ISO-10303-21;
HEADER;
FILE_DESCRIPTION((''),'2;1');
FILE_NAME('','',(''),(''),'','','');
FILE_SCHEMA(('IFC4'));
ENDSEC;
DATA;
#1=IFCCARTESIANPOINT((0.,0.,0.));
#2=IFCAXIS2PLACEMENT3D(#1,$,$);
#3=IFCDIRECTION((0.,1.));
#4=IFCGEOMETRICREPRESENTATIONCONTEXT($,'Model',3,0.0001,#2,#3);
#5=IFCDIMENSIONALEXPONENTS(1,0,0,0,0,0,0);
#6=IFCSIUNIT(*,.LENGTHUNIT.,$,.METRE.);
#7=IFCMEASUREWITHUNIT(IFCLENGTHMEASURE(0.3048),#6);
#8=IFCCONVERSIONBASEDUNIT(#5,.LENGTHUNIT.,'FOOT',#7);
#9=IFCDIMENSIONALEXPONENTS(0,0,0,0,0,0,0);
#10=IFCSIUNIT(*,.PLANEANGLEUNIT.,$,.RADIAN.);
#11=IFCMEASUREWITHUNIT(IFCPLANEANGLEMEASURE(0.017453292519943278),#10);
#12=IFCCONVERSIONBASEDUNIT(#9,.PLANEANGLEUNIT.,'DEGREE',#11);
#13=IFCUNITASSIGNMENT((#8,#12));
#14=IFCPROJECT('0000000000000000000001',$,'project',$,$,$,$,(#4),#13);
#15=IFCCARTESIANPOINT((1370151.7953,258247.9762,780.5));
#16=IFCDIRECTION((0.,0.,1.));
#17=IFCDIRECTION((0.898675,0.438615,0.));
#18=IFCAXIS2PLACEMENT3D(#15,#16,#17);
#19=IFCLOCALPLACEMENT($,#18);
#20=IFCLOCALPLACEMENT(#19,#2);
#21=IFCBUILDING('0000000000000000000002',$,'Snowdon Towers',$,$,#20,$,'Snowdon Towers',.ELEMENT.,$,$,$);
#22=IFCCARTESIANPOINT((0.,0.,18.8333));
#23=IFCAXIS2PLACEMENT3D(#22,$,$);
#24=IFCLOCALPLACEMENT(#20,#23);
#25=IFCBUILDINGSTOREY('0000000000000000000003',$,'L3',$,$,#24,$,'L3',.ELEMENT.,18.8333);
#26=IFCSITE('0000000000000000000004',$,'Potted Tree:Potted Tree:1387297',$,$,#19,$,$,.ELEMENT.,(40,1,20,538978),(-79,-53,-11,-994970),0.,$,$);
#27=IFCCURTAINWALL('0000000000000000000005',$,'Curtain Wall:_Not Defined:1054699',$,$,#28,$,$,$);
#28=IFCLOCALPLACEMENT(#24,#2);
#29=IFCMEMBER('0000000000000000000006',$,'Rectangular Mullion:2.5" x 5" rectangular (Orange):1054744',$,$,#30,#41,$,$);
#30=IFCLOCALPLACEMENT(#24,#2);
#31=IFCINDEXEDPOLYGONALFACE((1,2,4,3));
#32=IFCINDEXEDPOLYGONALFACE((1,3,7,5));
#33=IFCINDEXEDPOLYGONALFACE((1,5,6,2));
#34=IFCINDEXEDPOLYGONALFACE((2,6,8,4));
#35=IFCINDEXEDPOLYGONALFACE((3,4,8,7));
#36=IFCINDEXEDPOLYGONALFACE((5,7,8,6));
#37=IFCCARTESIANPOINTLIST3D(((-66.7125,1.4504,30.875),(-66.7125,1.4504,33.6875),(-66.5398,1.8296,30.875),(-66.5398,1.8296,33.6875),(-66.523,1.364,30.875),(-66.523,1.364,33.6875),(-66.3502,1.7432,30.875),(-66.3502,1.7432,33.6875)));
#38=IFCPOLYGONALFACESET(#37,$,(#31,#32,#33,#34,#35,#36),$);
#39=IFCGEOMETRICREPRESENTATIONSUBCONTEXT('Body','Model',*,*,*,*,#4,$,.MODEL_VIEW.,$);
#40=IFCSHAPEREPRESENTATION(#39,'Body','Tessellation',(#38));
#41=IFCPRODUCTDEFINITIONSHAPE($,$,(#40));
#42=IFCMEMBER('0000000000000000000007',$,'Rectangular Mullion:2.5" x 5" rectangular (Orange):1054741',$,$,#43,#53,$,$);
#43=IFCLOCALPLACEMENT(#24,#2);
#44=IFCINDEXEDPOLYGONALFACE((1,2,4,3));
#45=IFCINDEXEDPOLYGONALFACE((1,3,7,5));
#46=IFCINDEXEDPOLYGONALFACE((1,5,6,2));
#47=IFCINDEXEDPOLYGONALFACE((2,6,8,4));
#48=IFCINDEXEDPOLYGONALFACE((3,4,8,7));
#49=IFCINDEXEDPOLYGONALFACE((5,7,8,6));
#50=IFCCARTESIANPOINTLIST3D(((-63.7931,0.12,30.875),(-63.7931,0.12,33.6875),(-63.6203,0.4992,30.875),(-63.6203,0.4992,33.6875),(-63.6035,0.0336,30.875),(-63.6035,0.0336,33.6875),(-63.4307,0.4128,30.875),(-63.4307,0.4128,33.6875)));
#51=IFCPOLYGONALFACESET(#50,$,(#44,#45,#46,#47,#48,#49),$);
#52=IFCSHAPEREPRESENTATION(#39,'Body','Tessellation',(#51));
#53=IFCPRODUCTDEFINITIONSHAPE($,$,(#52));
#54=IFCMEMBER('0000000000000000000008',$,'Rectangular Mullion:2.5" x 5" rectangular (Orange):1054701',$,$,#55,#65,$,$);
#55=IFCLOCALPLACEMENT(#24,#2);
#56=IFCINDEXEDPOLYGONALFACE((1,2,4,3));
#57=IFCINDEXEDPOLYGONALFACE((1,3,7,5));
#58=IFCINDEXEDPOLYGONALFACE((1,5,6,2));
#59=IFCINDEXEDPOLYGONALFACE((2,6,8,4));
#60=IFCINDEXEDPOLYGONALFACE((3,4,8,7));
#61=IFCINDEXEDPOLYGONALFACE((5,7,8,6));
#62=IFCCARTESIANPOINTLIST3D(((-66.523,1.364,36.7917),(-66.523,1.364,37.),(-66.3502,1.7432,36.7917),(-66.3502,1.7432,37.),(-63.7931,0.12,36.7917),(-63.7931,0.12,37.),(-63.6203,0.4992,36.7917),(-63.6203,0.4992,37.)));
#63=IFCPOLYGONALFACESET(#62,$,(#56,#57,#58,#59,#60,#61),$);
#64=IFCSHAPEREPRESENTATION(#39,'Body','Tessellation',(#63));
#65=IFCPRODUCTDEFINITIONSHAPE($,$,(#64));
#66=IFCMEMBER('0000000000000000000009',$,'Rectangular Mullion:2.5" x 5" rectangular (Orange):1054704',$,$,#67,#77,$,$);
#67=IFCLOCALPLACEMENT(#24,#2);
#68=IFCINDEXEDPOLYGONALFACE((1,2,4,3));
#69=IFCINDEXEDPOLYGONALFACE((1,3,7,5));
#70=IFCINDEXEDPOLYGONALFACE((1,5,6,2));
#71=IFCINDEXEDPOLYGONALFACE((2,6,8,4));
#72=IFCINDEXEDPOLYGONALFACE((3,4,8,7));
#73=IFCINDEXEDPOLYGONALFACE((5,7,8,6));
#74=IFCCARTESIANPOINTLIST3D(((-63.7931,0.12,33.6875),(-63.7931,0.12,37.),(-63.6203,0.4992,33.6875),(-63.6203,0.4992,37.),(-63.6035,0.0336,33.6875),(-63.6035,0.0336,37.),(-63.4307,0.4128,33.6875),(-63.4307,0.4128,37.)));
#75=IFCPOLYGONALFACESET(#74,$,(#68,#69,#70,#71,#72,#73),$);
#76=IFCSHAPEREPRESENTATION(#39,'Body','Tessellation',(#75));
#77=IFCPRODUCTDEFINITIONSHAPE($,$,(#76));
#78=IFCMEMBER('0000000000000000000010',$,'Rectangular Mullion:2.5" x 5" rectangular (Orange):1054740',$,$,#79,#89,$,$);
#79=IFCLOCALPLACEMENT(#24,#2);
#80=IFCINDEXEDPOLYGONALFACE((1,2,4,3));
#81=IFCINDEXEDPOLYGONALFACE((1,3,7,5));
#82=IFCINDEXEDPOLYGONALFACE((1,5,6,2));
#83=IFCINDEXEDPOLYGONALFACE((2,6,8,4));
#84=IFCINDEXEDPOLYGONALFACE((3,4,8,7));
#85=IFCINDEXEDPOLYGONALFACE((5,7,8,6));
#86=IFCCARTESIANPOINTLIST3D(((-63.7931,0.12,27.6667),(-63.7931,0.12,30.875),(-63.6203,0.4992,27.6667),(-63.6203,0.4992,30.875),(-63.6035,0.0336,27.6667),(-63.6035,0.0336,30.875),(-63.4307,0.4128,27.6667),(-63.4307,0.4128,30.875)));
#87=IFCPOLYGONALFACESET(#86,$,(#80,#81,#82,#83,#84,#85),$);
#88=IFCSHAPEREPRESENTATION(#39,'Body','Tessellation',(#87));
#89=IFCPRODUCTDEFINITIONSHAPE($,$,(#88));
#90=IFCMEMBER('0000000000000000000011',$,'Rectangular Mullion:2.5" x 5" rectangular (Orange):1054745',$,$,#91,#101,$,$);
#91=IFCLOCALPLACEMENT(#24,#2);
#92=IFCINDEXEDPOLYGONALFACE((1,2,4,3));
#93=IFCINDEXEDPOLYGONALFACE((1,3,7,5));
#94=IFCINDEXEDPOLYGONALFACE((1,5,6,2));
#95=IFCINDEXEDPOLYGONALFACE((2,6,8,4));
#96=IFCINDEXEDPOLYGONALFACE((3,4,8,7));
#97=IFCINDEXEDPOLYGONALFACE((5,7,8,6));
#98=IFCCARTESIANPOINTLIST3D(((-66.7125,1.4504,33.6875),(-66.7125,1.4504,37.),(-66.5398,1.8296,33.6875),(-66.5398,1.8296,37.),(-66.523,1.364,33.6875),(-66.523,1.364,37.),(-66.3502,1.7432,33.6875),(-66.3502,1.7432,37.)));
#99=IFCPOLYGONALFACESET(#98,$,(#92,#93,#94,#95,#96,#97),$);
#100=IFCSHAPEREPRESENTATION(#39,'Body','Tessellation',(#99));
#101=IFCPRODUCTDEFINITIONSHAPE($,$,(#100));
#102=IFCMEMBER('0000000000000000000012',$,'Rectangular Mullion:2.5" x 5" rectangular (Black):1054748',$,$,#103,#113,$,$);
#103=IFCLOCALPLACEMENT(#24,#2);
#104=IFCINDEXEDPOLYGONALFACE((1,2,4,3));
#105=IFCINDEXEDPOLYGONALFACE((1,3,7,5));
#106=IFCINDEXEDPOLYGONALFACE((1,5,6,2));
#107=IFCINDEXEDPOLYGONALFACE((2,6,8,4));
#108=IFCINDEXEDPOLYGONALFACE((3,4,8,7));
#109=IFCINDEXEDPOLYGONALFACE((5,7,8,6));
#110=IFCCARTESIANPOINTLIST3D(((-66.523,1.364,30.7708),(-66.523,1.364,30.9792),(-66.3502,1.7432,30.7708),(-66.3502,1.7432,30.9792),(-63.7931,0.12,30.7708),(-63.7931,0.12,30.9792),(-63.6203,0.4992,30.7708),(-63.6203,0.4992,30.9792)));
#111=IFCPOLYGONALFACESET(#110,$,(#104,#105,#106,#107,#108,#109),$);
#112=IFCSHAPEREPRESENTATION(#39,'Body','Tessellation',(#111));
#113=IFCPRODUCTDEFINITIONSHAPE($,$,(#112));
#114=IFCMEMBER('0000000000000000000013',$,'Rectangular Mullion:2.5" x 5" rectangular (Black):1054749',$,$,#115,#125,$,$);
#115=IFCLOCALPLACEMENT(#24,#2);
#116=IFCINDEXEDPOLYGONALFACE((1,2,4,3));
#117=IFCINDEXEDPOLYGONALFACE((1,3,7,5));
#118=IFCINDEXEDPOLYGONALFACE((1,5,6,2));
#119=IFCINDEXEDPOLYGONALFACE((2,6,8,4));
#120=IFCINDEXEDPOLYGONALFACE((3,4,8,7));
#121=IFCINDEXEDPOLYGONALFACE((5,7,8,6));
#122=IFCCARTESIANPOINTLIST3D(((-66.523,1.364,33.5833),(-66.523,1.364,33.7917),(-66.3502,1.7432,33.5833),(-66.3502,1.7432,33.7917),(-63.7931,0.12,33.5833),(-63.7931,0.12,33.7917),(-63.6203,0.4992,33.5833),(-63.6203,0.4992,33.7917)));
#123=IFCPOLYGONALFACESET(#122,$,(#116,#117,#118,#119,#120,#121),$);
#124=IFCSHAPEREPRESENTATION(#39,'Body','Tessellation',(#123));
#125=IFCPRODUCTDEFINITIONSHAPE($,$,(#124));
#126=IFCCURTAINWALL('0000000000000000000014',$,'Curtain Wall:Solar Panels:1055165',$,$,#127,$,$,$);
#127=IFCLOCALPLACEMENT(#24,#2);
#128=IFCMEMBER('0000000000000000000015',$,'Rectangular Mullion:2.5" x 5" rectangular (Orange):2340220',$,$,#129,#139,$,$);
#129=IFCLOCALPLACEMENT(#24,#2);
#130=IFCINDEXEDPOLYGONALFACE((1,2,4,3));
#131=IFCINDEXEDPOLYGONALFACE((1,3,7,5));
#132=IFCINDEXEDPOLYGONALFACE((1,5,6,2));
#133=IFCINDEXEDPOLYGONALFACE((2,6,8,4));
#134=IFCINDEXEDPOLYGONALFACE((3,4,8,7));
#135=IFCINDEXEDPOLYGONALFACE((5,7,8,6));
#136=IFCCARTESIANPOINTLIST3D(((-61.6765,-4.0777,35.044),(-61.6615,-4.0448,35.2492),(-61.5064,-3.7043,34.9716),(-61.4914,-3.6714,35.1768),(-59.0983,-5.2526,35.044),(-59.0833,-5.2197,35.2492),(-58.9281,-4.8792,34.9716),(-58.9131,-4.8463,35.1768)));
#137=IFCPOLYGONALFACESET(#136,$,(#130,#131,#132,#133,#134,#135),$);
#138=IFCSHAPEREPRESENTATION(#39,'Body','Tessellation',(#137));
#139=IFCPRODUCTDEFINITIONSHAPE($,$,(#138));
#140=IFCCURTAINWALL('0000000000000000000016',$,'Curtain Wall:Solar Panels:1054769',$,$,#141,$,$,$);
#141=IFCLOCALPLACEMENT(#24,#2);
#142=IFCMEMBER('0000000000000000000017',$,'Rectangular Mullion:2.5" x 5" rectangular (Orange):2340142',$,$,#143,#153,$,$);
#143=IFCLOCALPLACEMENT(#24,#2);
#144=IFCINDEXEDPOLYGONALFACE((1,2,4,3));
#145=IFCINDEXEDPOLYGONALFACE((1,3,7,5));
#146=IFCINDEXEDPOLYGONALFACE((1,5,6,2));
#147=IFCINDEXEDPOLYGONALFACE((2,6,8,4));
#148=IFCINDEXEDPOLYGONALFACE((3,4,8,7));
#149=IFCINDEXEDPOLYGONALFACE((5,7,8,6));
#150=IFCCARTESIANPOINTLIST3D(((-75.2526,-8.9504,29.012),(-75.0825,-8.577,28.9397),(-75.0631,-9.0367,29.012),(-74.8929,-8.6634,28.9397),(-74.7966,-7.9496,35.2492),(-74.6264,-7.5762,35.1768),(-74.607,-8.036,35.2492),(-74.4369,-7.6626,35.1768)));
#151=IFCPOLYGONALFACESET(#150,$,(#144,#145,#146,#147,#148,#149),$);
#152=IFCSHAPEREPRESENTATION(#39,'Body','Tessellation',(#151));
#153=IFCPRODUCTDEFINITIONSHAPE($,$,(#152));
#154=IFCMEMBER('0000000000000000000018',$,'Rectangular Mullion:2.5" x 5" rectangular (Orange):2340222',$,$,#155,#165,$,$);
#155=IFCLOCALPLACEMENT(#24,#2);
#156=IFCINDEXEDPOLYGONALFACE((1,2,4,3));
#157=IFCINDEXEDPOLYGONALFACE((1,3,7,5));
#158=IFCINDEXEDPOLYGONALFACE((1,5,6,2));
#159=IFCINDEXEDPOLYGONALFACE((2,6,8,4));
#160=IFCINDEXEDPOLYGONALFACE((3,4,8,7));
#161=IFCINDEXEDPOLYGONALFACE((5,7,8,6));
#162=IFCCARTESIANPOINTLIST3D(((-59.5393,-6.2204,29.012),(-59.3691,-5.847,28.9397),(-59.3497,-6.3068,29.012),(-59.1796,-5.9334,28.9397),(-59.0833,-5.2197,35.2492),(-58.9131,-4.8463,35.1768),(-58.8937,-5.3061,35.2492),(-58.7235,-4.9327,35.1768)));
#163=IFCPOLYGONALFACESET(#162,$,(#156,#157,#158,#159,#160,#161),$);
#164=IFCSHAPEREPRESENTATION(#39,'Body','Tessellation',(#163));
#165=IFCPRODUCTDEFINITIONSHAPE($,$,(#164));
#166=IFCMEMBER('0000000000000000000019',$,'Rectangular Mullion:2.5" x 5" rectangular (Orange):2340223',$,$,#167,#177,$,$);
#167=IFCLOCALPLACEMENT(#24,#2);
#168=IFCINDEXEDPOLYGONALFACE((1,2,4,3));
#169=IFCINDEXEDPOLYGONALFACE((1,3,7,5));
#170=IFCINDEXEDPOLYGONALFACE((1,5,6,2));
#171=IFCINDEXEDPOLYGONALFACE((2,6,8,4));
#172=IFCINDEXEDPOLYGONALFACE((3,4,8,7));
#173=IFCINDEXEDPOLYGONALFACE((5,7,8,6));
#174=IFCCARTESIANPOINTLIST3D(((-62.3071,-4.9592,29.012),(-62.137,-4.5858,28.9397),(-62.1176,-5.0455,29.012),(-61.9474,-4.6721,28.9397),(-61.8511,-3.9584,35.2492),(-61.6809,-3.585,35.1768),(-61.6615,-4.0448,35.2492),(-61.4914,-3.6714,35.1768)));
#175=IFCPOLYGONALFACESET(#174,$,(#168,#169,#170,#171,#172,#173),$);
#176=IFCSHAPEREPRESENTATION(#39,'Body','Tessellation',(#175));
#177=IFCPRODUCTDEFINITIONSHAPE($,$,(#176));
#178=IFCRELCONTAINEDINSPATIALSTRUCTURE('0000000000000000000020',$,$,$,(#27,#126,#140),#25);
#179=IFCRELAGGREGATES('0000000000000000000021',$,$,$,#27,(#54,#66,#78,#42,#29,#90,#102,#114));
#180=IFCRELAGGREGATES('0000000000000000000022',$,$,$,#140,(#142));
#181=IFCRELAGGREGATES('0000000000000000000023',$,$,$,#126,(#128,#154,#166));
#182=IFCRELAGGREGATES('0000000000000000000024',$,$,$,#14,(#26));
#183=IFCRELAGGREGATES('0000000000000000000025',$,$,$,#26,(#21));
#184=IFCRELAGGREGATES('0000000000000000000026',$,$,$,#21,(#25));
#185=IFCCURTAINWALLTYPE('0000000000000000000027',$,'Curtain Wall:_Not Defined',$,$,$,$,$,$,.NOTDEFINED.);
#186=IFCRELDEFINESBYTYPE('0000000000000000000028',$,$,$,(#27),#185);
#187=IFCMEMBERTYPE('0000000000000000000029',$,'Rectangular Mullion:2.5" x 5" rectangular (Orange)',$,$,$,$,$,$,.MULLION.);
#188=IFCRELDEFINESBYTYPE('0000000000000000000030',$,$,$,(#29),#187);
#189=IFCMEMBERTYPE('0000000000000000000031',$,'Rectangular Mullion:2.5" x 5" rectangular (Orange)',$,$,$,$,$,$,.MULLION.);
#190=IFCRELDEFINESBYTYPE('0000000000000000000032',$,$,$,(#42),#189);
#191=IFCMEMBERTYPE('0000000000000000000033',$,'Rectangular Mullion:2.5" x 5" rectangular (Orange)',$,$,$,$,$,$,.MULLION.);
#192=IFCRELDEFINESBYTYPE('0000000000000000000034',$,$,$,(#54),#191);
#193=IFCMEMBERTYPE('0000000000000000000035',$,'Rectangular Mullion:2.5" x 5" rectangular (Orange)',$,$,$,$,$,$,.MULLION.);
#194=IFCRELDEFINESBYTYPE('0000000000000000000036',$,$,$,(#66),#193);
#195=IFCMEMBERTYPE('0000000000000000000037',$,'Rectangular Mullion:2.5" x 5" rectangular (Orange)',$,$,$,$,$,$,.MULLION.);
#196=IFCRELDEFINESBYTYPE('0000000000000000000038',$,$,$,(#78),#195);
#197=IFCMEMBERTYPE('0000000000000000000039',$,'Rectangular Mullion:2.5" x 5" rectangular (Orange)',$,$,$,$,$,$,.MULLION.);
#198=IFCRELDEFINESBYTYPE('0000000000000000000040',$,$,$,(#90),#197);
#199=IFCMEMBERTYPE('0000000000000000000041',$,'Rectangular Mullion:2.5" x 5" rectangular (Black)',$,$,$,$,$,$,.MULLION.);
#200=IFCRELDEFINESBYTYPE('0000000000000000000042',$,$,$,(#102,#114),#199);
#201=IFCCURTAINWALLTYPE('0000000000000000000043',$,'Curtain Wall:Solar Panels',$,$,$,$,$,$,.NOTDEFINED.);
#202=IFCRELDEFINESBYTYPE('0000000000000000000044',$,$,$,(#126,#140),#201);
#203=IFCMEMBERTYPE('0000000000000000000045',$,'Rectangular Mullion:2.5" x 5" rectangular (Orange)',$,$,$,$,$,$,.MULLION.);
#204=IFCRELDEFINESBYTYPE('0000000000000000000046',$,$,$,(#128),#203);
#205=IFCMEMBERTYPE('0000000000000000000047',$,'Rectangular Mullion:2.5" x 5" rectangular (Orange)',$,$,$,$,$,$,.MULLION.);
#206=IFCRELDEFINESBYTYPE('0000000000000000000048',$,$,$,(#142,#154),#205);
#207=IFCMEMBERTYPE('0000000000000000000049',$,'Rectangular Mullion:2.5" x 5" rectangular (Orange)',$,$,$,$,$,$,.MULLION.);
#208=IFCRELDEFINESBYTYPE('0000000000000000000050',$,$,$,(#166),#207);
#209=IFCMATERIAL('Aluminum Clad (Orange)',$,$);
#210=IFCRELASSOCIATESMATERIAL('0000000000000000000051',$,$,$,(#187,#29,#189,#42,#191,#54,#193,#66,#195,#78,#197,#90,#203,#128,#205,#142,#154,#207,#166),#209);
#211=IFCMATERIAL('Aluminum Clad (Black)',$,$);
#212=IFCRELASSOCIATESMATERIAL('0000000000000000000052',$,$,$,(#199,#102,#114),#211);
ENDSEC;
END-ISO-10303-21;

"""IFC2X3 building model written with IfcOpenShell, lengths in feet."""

from ifc_helpers import new_model, entity, si_unit, converted_unit, direction, frame, frame_2d, origin, origin_2d_with_axis, place, context, subcontext, project, spatial, rectangle, extrude, source, transform, mapped, material, type_object, type_shapes, element, aggregate, save


model = new_model("IFC2X3")

# Units and contexts
model_context = context("Model", 3, precision=0.0001, world=origin(), true_north=direction((0.0, 1.0)))
body_context = subcontext(model_context, "Body", "Model", "MODEL_VIEW")
ifc_project = project(units=[converted_unit("LENGTHUNIT", "FOOT", entity("IfcLengthMeasure", 0.3048), si_unit("LENGTHUNIT", "METRE"), dimensions=[1, 0, 0, 0, 0, 0, 0]), converted_unit("PLANEANGLEUNIT", "DEGREE", entity("IfcPlaneAngleMeasure", 0.017453292519943278), si_unit("PLANEANGLEUNIT", "RADIAN"), dimensions=[0, 0, 0, 0, 0, 0, 0])], contexts=[model_context])

# Site, building, storey
site_placement = place(None, frame((1370151.7953, 258247.9762, 780.5), z_axis=(0.0, 0.0, 1.0), x_axis=(0.898675, 0.438615, 0.0)))
site = spatial("IfcSite", under=ifc_project, at=site_placement, Name="Potted Tree:Potted Tree:1387297", CompositionType="ELEMENT", RefLatitude=(40, 1, 20, 538978), RefLongitude=(-79, -53, -11, -994970), RefElevation=0.0)
building_placement = place(site_placement, origin())
building = spatial("IfcBuilding", under=site, at=building_placement, Name="Snowdon Towers", LongName="Snowdon Towers", CompositionType="ELEMENT")
storey_placement = place(building_placement, frame((0.0, 0.0, 18.8333)))
storey = spatial("IfcBuildingStorey", under=building, at=storey_placement, Name="L3", LongName="L3", CompositionType="ELEMENT", Elevation=18.8333)

# Curtain wall, members
curtain_wall_type_1 = type_object("IfcCurtainWallType", Name="Curtain Wall:_Not Defined", PredefinedType="NOTDEFINED")
curtain_wall_1_placement = place(storey_placement, frame((0.0, 0.0, -18.8333)))
curtain_wall_1 = element("IfcCurtainWall", 1, at=curtain_wall_1_placement, inside=storey, type_object=curtain_wall_type_1, Name="Curtain Wall:_Not Defined:1054699")
ifc_material_1 = material(Name="Aluminum Clad (Orange)")
member_type_1 = type_object("IfcMemberType", Name="Rectangular Mullion:2.5\" x 5\" rectangular (Orange)", PredefinedType="MULLION", material=ifc_material_1)
shared_shape_1 = source(origin(), body_context, "Body", "SweptSolid", [
    extrude(rectangle(XDim=0.2083, YDim=0.4167, at=frame_2d((0.0, 0.0), x_axis=(1.0, 0.0))), frame((-0.1042, 0.0, -2.8125), z_axis=(0.0, 0.0, 1.0), x_axis=(-1.0, 0.0, 0.0)), (0.0, 0.0, 1.0), 2.8125),
])
type_shapes(member_type_1, [shared_shape_1])
member_1_placement = place(curtain_wall_1_placement, frame((-66.6262, 1.64, 49.7083), z_axis=(0.0, 0.0, -1.0), x_axis=(-0.909972, 0.414671, 0.0)))
member_1 = element("IfcMember", 2, at=member_1_placement, type_object=member_type_1, material=ifc_material_1, Name="Rectangular Mullion:2.5\" x 5\" rectangular (Orange):1054744", context=body_context, shape_type="MappedRepresentation", body=[
    mapped(shared_shape_1, transform((0.0, 0.0, 0.0), scale=1.0)),
])
member_type_2 = type_object("IfcMemberType", Name="Rectangular Mullion:2.5\" x 5\" rectangular (Orange)", PredefinedType="MULLION", material=ifc_material_1)
shared_shape_2 = source(origin(), body_context, "Body", "SweptSolid", [
    extrude(rectangle(XDim=0.2083, YDim=0.4167, at=frame_2d((0.0, 0.0), x_axis=(1.0, 0.0))), frame((-0.1042, 0.0, -2.8125), z_axis=(0.0, 0.0, 1.0), x_axis=(-1.0, 0.0, 0.0)), (0.0, 0.0, 1.0), 2.8125),
])
type_shapes(member_type_2, [shared_shape_2])
member_2_placement = place(curtain_wall_1_placement, frame((-63.5171, 0.2232, 52.5208), z_axis=(0.0, 0.0, 1.0), x_axis=(0.909972, -0.414671, 0.0)))
member_2 = element("IfcMember", 3, at=member_2_placement, type_object=member_type_2, material=ifc_material_1, Name="Rectangular Mullion:2.5\" x 5\" rectangular (Orange):1054741", context=body_context, shape_type="MappedRepresentation", body=[
    mapped(shared_shape_2, transform((0.0, 0.0, 0.0), scale=1.0)),
])
member_type_3 = type_object("IfcMemberType", Name="Rectangular Mullion:2.5\" x 5\" rectangular (Orange)", PredefinedType="MULLION", material=ifc_material_1)
shared_shape_3 = source(origin(), body_context, "Body", "SweptSolid", [
    extrude(rectangle(XDim=0.2083, YDim=0.4167, at=frame_2d((0.0, 0.0), x_axis=(1.0, 0.0))), frame((-0.1042, 0.0, -3.0), z_axis=(0.0, 0.0, 1.0), x_axis=(-1.0, 0.0, 0.0)), (0.0, 0.0, 1.0), 3.0),
])
type_shapes(member_type_3, [shared_shape_3])
member_3_placement = place(curtain_wall_1_placement, frame((-66.4366, 1.5536, 55.8333), z_axis=(-0.909972, 0.414671, 0.0), x_axis=(0.0, 0.0, 1.0)))
member_3 = element("IfcMember", 4, at=member_3_placement, type_object=member_type_3, material=ifc_material_1, Name="Rectangular Mullion:2.5\" x 5\" rectangular (Orange):1054701", context=body_context, shape_type="MappedRepresentation", body=[
    mapped(shared_shape_3, transform((0.0, 0.0, 0.0), scale=1.0)),
])
member_type_4 = type_object("IfcMemberType", Name="Rectangular Mullion:2.5\" x 5\" rectangular (Orange)", PredefinedType="MULLION", material=ifc_material_1)
shared_shape_4 = source(origin(), body_context, "Body", "SweptSolid", [
    extrude(rectangle(XDim=0.2083, YDim=0.4167, at=frame_2d((0.0, 0.0), x_axis=(1.0, 0.0))), frame((-0.1042, 0.0, -3.3125), z_axis=(0.0, 0.0, 1.0), x_axis=(-1.0, 0.0, 0.0)), (0.0, 0.0, 1.0), 3.3125),
])
type_shapes(member_type_4, [shared_shape_4])
member_4_placement = place(curtain_wall_1_placement, frame((-63.5171, 0.2232, 55.8333), z_axis=(0.0, 0.0, 1.0), x_axis=(0.909972, -0.414671, 0.0)))
member_4 = element("IfcMember", 5, at=member_4_placement, type_object=member_type_4, material=ifc_material_1, Name="Rectangular Mullion:2.5\" x 5\" rectangular (Orange):1054704", context=body_context, shape_type="MappedRepresentation", body=[
    mapped(shared_shape_4, transform((0.0, 0.0, 0.0), scale=1.0)),
])
member_type_5 = type_object("IfcMemberType", Name="Rectangular Mullion:2.5\" x 5\" rectangular (Orange)", PredefinedType="MULLION", material=ifc_material_1)
shared_shape_5 = source(origin(), body_context, "Body", "SweptSolid", [
    extrude(rectangle(XDim=0.2083, YDim=0.4167, at=frame_2d((0.0, 0.0), x_axis=(1.0, 0.0))), frame((-0.1042, 0.0, -3.2083), z_axis=(0.0, 0.0, 1.0), x_axis=(-1.0, 0.0, 0.0)), (0.0, 0.0, 1.0), 3.2083),
])
type_shapes(member_type_5, [shared_shape_5])
member_5_placement = place(curtain_wall_1_placement, frame((-63.5171, 0.2232, 49.7083), z_axis=(0.0, 0.0, 1.0), x_axis=(0.909972, -0.414671, 0.0)))
member_5 = element("IfcMember", 6, at=member_5_placement, type_object=member_type_5, material=ifc_material_1, Name="Rectangular Mullion:2.5\" x 5\" rectangular (Orange):1054740", context=body_context, shape_type="MappedRepresentation", body=[
    mapped(shared_shape_5, transform((0.0, 0.0, 0.0), scale=1.0)),
])
member_type_6 = type_object("IfcMemberType", Name="Rectangular Mullion:2.5\" x 5\" rectangular (Orange)", PredefinedType="MULLION", material=ifc_material_1)
shared_shape_6 = source(origin(), body_context, "Body", "SweptSolid", [
    extrude(rectangle(XDim=0.2083, YDim=0.4167, at=frame_2d((0.0, 0.0), x_axis=(1.0, 0.0))), frame((-0.1042, 0.0, -3.3125), z_axis=(0.0, 0.0, 1.0), x_axis=(-1.0, 0.0, 0.0)), (0.0, 0.0, 1.0), 3.3125),
])
type_shapes(member_type_6, [shared_shape_6])
member_6_placement = place(curtain_wall_1_placement, frame((-66.6262, 1.64, 52.5208), z_axis=(0.0, 0.0, -1.0), x_axis=(-0.909972, 0.414671, 0.0)))
member_6 = element("IfcMember", 7, at=member_6_placement, type_object=member_type_6, material=ifc_material_1, Name="Rectangular Mullion:2.5\" x 5\" rectangular (Orange):1054745", context=body_context, shape_type="MappedRepresentation", body=[
    mapped(shared_shape_6, transform((0.0, 0.0, 0.0), scale=1.0)),
])
ifc_material_2 = material(Name="Aluminum Clad (Black)")
member_type_7 = type_object("IfcMemberType", Name="Rectangular Mullion:2.5\" x 5\" rectangular (Black)", PredefinedType="MULLION", material=ifc_material_2)
shared_shape_7 = source(origin(), body_context, "Body", "SweptSolid", [
    extrude(rectangle(XDim=0.2083, YDim=0.4167, at=origin_2d_with_axis()), frame((0.0, 0.0, -3.0), z_axis=(0.0, 0.0, 1.0), x_axis=(-1.0, 0.0, 0.0)), (0.0, 0.0, 1.0), 3.0),
])
type_shapes(member_type_7, [shared_shape_7])
member_7_placement = place(curtain_wall_1_placement, frame((-66.4366, 1.5536, 49.7083), z_axis=(-0.909972, 0.414671, 0.0), x_axis=(0.0, 0.0, 1.0)))
member_7 = element("IfcMember", 8, at=member_7_placement, type_object=member_type_7, material=ifc_material_2, Name="Rectangular Mullion:2.5\" x 5\" rectangular (Black):1054748", context=body_context, shape_type="MappedRepresentation", body=[
    mapped(shared_shape_7, transform((0.0, 0.0, 0.0), scale=1.0)),
])
member_8_placement = place(curtain_wall_1_placement, frame((-66.4366, 1.5536, 52.5208), z_axis=(-0.909972, 0.414671, 0.0), x_axis=(0.0, 0.0, 1.0)))
member_8 = element("IfcMember", 9, at=member_8_placement, type_object=member_type_7, material=ifc_material_2, Name="Rectangular Mullion:2.5\" x 5\" rectangular (Black):1054749", context=body_context, shape_type="MappedRepresentation", body=[
    mapped(shared_shape_7, transform((0.0, 0.0, 0.0), scale=1.0)),
])

# Curtain walls, members
curtain_wall_type_2 = type_object("IfcCurtainWallType", Name="Curtain Wall:Solar Panels", PredefinedType="NOTDEFINED")
curtain_wall_2_placement = place(storey_placement, frame((0.0, 0.0, -18.8333)))
curtain_wall_2 = element("IfcCurtainWall", 10, at=curtain_wall_2_placement, inside=storey, type_object=curtain_wall_type_2, Name="Curtain Wall:Solar Panels:1055165")
member_type_8 = type_object("IfcMemberType", Name="Rectangular Mullion:2.5\" x 5\" rectangular (Orange)", PredefinedType="MULLION", material=ifc_material_1)
shared_shape_8 = source(origin(), body_context, "Body", "SweptSolid", [
    extrude(rectangle(XDim=0.2083, YDim=0.4167, at=frame_2d((0.0, 0.0), x_axis=(1.0, 0.0))), frame((-0.1042, 0.0, -2.8333), z_axis=(0.0, 0.0, 1.0), x_axis=(-1.0, 0.0, 0.0)), (0.0, 0.0, 1.0), 2.8333),
])
type_shapes(member_type_8, [shared_shape_8])
member_9_placement = place(curtain_wall_2_placement, frame((-58.9982, -5.033, 54.0463), z_axis=(0.909972, -0.414671, 0.0), x_axis=(0.072007, 0.158015, 0.984808)))
member_9 = element("IfcMember", 11, at=member_9_placement, type_object=member_type_8, material=ifc_material_1, Name="Rectangular Mullion:2.5\" x 5\" rectangular (Orange):2340220", context=body_context, shape_type="MappedRepresentation", body=[
    mapped(shared_shape_8, transform((0.0, 0.0, 0.0), scale=1.0)),
])
curtain_wall_3_placement = place(storey_placement, frame((0.0, 0.0, -18.8333)))
curtain_wall_3 = element("IfcCurtainWall", 12, at=curtain_wall_3_placement, inside=storey, type_object=curtain_wall_type_2, Name="Curtain Wall:Solar Panels:1054769")
member_type_9 = type_object("IfcMemberType", Name="Rectangular Mullion:2.5\" x 5\" rectangular (Orange)", PredefinedType="MULLION", material=ifc_material_1)
shared_shape_9 = source(origin(), body_context, "Body", "SweptSolid", [
    extrude(rectangle(XDim=0.2083, YDim=0.4167, at=frame_2d((0.0, 0.0), x_axis=(1.0, 0.0))), frame((-0.1042, 0.0, -6.3333), z_axis=(0.0, 0.0, 1.0), x_axis=(-1.0, 0.0, 0.0)), (0.0, 0.0, 1.0), 6.3333),
])
type_shapes(member_type_9, [shared_shape_9])
member_10_placement = place(curtain_wall_3_placement, frame((-74.978, -8.85, 47.8092), z_axis=(-0.072007, -0.158015, -0.984808), x_axis=(0.909972, -0.414671, 0.0)))
member_10 = element("IfcMember", 13, at=member_10_placement, type_object=member_type_9, material=ifc_material_1, Name="Rectangular Mullion:2.5\" x 5\" rectangular (Orange):2340142", context=body_context, shape_type="MappedRepresentation", body=[
    mapped(shared_shape_9, transform((0.0, 0.0, 0.0), scale=1.0)),
])

# Members
member_11_placement = place(curtain_wall_2_placement, frame((-59.2646, -6.1201, 47.8092), z_axis=(-0.072007, -0.158015, -0.984808), x_axis=(0.909972, -0.414671, 0.0)))
member_11 = element("IfcMember", 14, at=member_11_placement, type_object=member_type_9, material=ifc_material_1, Name="Rectangular Mullion:2.5\" x 5\" rectangular (Orange):2340222", context=body_context, shape_type="MappedRepresentation", body=[
    mapped(shared_shape_9, transform((0.0, 0.0, 0.0), scale=1.0)),
])
member_type_10 = type_object("IfcMemberType", Name="Rectangular Mullion:2.5\" x 5\" rectangular (Orange)", PredefinedType="MULLION", material=ifc_material_1)
shared_shape_10 = source(origin(), body_context, "Body", "SweptSolid", [
    extrude(rectangle(XDim=0.2083, YDim=0.4167, at=frame_2d((0.0, 0.0), x_axis=(1.0, 0.0))), frame((-0.1042, 0.0, -6.3333), z_axis=(0.0, 0.0, 1.0), x_axis=(-1.0, 0.0, 0.0)), (0.0, 0.0, 1.0), 6.3333),
])
type_shapes(member_type_10, [shared_shape_10])
member_12_placement = place(curtain_wall_2_placement, frame((-61.766, -3.7717, 54.0463), z_axis=(0.072007, 0.158015, 0.984808), x_axis=(-0.909972, 0.414671, 0.0)))
member_12 = element("IfcMember", 15, at=member_12_placement, type_object=member_type_10, material=ifc_material_1, Name="Rectangular Mullion:2.5\" x 5\" rectangular (Orange):2340223", context=body_context, shape_type="MappedRepresentation", body=[
    mapped(shared_shape_10, transform((0.0, 0.0, 0.0), scale=1.0)),
])

aggregate(curtain_wall_1, [member_3, member_4, member_5, member_2, member_1, member_6, member_7, member_8])
aggregate(curtain_wall_3, [member_10])
aggregate(curtain_wall_2, [member_9, member_11, member_12])

save(model, "model.ifc")
